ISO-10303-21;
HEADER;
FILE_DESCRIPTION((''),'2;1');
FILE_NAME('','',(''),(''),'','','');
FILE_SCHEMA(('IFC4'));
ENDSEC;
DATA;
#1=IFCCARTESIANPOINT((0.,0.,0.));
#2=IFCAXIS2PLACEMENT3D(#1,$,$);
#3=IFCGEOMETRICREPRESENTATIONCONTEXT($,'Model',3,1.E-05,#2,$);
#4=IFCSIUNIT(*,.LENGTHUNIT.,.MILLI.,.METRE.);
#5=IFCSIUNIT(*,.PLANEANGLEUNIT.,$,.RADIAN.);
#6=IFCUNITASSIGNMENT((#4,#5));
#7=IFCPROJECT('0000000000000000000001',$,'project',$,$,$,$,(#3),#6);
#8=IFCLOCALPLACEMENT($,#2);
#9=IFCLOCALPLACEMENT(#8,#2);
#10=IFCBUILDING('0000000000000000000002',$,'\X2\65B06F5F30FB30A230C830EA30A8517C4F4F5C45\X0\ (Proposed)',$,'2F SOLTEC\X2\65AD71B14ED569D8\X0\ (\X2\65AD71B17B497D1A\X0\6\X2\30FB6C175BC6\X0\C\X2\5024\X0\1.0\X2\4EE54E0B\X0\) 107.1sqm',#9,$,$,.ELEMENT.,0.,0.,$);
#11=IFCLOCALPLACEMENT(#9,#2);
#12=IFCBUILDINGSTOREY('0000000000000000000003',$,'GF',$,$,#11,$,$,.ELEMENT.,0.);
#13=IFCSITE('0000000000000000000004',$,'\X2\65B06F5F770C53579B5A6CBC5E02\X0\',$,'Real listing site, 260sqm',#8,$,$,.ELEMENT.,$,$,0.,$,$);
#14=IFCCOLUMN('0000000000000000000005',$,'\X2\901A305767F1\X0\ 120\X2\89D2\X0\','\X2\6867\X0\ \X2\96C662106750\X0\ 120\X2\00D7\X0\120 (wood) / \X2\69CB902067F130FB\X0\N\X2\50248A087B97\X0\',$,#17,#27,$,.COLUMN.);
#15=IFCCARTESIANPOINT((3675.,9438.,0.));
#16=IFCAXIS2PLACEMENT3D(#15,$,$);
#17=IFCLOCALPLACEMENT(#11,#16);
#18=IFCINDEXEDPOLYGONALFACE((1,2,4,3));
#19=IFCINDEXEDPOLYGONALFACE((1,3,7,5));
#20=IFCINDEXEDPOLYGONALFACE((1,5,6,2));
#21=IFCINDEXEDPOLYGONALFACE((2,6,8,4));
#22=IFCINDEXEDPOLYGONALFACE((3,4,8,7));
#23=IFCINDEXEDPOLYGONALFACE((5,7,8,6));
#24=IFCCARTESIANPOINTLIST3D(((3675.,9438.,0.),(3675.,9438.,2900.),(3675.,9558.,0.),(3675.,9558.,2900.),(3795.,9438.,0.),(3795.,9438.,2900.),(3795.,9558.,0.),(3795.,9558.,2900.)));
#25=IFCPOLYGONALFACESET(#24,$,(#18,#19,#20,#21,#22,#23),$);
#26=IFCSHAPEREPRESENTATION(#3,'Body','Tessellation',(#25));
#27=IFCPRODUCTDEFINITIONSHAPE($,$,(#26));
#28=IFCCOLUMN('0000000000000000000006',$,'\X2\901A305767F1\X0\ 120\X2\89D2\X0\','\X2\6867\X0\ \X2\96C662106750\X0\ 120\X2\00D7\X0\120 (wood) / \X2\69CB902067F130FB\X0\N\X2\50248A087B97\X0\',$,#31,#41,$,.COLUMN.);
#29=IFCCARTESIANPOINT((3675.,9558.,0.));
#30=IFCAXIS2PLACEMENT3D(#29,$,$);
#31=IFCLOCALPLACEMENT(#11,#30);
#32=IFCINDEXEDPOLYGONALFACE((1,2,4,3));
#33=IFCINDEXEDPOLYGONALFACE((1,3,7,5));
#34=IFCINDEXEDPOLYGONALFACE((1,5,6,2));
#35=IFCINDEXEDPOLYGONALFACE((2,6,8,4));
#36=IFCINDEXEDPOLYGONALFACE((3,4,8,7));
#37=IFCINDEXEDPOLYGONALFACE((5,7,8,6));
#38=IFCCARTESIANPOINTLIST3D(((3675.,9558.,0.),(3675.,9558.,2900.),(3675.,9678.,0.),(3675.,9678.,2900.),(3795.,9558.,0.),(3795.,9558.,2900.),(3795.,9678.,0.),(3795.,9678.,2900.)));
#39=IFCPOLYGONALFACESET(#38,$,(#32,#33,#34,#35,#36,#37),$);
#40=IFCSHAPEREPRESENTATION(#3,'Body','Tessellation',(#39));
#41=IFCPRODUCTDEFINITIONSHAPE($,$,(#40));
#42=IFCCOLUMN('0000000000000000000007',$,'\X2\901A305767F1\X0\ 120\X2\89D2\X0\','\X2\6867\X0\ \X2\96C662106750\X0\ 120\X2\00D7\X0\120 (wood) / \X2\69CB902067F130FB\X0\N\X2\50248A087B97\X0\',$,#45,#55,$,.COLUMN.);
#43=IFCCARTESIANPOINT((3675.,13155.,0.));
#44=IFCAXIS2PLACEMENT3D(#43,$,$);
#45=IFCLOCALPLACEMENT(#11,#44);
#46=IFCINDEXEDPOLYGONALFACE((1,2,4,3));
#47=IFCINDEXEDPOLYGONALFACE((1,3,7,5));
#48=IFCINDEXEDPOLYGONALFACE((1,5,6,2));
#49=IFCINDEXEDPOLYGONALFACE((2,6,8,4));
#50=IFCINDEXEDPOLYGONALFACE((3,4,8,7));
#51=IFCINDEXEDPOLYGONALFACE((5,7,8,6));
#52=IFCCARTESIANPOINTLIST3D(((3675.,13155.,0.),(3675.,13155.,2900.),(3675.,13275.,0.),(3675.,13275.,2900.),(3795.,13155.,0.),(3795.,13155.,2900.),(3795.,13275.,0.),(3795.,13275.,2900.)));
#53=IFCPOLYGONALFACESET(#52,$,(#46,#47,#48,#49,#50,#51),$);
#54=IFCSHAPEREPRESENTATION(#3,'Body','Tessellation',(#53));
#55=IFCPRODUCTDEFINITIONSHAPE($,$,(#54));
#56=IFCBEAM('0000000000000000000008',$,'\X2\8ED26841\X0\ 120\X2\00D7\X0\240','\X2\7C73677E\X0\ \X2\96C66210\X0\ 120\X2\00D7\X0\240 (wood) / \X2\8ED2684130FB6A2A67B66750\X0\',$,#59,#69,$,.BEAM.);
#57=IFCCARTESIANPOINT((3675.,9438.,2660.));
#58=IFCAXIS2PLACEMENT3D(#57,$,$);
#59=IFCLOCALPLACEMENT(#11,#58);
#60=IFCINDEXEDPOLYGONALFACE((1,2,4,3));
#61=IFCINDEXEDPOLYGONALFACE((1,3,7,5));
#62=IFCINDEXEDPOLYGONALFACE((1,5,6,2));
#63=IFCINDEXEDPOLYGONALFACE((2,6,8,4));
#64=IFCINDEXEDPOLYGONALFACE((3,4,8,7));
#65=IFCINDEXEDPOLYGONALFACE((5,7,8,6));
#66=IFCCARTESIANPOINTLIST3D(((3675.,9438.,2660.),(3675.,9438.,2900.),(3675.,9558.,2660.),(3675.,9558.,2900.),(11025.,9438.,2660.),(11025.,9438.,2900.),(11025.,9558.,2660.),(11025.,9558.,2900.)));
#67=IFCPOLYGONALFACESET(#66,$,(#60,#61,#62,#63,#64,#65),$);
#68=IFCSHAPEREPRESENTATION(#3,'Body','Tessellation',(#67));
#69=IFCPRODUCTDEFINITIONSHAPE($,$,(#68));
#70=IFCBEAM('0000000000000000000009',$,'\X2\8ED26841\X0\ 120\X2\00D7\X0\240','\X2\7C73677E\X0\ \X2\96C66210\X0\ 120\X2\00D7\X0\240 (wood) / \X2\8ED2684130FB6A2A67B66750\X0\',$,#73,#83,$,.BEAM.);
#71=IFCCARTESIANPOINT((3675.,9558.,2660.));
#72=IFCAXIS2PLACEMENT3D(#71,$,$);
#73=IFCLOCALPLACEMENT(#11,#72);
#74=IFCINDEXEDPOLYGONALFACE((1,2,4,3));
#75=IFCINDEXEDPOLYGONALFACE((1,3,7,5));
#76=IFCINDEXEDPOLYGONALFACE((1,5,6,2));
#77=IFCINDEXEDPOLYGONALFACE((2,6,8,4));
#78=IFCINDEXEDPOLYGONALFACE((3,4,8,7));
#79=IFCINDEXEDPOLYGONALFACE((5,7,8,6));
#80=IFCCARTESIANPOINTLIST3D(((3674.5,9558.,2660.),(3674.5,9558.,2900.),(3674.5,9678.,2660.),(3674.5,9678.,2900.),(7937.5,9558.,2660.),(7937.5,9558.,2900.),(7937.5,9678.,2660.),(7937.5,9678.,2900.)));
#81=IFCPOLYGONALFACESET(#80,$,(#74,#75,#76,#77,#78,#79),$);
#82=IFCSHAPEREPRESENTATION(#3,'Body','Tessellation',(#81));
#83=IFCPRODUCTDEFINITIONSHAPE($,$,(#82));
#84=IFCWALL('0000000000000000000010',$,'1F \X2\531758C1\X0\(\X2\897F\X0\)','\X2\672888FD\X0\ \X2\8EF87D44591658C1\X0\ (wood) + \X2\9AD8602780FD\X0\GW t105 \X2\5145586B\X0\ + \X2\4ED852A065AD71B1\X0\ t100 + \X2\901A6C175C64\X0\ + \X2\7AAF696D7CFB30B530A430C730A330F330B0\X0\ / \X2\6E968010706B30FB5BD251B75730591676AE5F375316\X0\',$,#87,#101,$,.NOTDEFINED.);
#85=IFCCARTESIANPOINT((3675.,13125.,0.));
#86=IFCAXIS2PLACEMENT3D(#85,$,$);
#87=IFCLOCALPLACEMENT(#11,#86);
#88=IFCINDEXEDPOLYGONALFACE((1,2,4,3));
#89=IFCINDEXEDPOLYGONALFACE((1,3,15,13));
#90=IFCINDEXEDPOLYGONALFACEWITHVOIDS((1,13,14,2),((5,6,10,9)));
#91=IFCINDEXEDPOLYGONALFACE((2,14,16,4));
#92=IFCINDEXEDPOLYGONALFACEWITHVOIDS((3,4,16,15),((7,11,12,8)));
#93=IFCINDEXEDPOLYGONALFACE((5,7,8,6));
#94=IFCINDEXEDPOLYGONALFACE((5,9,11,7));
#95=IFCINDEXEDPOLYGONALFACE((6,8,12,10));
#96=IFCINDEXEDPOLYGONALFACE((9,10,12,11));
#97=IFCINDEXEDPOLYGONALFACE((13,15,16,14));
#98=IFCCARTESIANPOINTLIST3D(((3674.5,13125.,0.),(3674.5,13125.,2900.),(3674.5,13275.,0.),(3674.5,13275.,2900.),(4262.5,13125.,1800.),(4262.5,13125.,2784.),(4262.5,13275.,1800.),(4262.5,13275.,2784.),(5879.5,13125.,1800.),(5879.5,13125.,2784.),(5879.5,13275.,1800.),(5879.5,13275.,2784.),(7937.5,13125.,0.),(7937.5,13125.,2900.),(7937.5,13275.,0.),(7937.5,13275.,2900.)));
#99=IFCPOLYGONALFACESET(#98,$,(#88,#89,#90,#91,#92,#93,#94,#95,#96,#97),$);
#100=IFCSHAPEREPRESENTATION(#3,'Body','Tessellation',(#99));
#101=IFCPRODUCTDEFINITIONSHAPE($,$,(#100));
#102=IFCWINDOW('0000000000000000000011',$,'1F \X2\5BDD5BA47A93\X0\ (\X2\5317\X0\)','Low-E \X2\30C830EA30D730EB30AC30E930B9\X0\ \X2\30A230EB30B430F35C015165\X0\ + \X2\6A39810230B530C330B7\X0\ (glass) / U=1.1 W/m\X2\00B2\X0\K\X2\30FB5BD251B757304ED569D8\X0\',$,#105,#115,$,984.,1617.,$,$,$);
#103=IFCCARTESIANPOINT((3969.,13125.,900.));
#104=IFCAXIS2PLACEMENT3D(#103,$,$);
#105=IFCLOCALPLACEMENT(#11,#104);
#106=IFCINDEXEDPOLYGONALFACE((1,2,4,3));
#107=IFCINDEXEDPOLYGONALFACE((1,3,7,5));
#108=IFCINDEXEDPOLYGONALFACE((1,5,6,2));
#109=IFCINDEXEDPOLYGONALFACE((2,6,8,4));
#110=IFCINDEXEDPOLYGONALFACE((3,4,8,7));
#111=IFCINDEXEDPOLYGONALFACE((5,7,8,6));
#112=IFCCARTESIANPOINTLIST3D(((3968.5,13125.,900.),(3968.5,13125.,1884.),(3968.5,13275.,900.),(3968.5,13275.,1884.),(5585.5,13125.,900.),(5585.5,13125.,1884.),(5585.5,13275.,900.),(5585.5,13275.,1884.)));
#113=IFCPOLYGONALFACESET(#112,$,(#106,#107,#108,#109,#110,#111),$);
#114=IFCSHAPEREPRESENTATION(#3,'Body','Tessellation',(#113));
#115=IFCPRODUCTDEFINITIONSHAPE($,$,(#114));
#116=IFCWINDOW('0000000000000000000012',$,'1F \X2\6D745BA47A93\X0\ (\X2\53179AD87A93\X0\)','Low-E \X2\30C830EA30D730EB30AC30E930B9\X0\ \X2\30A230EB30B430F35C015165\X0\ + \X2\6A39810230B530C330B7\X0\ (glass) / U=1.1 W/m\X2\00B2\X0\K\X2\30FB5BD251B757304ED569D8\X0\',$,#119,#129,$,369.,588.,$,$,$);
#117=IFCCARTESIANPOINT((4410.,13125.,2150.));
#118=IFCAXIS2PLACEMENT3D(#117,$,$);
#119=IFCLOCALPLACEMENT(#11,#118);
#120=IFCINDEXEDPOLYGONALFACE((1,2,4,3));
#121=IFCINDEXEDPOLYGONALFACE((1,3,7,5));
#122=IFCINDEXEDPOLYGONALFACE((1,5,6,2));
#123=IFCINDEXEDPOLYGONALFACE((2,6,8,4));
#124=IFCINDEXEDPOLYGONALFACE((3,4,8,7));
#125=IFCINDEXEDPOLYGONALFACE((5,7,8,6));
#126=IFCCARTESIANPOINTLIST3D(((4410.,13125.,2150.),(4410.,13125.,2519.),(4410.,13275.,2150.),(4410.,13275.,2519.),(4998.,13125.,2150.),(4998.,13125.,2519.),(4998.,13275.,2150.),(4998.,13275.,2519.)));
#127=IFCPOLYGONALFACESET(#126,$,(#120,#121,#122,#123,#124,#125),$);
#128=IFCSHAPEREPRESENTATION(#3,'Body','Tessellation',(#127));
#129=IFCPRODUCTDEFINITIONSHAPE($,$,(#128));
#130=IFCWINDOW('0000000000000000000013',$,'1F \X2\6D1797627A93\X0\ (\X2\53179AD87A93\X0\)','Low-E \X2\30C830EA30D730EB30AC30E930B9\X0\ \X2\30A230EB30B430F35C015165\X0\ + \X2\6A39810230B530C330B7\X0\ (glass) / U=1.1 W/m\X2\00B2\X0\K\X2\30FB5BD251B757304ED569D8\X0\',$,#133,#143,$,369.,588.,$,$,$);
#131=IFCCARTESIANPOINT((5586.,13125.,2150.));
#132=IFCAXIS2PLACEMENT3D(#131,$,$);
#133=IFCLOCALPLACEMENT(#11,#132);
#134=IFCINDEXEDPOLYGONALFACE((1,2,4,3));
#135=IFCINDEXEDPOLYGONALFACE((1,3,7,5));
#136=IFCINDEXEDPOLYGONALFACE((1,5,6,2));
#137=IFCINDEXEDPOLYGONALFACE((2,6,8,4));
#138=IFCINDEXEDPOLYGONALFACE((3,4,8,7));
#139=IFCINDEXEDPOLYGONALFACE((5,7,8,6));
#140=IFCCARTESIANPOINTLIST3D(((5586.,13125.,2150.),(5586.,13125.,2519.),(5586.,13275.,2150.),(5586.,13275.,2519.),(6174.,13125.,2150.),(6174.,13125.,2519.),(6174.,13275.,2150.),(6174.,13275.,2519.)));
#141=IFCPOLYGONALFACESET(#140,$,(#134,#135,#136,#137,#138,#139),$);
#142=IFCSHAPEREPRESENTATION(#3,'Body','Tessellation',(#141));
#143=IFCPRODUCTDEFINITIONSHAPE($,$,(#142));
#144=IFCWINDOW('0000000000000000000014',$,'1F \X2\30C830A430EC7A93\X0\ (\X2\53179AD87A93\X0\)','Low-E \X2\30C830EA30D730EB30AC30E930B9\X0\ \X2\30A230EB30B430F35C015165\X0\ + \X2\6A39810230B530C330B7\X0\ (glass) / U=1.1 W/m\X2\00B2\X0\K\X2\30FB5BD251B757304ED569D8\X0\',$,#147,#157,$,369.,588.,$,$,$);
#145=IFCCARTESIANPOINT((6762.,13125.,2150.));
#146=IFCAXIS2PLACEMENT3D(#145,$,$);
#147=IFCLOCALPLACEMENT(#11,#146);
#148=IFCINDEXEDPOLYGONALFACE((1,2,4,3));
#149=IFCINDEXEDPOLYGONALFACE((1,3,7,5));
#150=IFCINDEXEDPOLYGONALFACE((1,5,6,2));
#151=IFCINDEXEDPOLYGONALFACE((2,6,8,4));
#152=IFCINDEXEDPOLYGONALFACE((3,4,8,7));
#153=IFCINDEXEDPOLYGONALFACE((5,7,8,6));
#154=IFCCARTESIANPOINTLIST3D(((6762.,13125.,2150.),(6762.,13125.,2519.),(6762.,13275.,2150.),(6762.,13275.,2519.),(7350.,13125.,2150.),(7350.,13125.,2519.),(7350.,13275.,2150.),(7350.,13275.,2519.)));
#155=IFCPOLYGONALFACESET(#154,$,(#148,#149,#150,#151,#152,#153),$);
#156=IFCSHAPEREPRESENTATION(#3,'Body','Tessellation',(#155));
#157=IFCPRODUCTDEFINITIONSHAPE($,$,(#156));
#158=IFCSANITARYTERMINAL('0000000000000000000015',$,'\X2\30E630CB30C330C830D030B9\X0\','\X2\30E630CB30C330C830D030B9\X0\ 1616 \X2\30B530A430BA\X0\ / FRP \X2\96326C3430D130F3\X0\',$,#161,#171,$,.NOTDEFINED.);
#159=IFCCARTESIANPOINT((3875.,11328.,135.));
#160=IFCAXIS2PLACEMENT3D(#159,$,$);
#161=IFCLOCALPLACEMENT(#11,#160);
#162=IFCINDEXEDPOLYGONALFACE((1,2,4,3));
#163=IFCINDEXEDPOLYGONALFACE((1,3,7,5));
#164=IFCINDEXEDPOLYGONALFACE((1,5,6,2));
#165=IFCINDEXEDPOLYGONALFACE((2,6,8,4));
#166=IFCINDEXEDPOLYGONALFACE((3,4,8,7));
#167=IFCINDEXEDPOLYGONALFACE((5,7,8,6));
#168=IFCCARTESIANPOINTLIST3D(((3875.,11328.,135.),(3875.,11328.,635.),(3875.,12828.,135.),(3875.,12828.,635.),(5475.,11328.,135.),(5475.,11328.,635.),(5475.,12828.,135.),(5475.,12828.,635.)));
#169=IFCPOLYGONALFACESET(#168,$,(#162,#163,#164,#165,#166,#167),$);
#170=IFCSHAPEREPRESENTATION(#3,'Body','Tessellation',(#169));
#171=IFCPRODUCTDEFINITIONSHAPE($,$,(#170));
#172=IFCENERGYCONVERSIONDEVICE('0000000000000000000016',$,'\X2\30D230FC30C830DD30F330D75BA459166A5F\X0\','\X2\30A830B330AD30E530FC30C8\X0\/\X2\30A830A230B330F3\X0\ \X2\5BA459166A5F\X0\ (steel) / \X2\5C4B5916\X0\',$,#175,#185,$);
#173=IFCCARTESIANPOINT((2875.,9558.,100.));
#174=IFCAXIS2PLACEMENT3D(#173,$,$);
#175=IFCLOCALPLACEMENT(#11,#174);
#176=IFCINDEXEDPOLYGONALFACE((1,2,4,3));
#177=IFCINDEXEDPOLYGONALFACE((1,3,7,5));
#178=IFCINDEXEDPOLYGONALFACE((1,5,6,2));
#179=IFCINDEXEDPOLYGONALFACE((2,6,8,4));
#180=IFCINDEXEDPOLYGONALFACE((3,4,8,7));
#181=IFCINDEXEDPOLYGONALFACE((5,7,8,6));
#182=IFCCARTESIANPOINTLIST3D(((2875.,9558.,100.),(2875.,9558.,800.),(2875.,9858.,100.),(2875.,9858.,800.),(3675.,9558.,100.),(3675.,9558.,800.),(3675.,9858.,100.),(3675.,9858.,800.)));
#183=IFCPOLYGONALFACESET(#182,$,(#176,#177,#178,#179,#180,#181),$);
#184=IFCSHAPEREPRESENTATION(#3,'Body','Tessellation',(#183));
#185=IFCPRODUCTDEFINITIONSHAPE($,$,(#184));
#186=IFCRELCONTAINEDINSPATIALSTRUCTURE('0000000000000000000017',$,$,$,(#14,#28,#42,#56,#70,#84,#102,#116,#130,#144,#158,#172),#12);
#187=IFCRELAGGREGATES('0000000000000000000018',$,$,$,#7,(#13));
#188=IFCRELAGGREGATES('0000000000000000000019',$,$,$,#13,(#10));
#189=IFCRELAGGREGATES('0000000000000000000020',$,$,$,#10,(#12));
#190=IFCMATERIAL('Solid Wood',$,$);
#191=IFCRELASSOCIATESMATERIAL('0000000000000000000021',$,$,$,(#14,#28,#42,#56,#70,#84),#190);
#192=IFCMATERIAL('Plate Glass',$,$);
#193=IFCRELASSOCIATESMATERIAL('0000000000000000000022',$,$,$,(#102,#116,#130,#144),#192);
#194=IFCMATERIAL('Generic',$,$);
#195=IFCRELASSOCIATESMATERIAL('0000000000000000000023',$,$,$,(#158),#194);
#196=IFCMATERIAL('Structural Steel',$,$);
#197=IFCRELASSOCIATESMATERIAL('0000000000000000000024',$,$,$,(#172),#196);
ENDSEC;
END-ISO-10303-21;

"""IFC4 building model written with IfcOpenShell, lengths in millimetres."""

from ifc_helpers import new_model, si_unit, frame, frame_2d, origin, place, context, project, spatial, rectangle, extrude, material, element, fill, save


model = new_model("IFC4")

# Units and contexts
model_context = context("Model", 3, precision=1e-05, world=origin())
ifc_project = project(units=[si_unit("LENGTHUNIT", "METRE", prefix="MILLI"), si_unit("PLANEANGLEUNIT", "RADIAN")], contexts=[model_context])

# Site, building, storey
site_placement = place(None, origin())
site = spatial("IfcSite", under=ifc_project, at=site_placement, Name="新潟県南魚沼市", ObjectType="Real listing site, 260sqm", CompositionType="ELEMENT", RefElevation=0.0)
building_placement = place(site_placement, origin())
building = spatial("IfcBuilding", under=site, at=building_placement, Name="新潟・アトリエ兼住居 (Proposed)", ObjectType="2F SOLTEC断熱仕様 (断熱等級6・気密C値1.0以下) 107.1sqm", CompositionType="ELEMENT", ElevationOfRefHeight=0.0, ElevationOfTerrain=0.0)
storey_placement = place(building_placement, origin())
storey = spatial("IfcBuildingStorey", under=building, at=storey_placement, Name="GF", CompositionType="ELEMENT", Elevation=0.0)

# Columns
ifc_material_1 = material(Name="Solid Wood")
column_1_placement = place(storey_placement, frame((3675.0, 9438.0, 0.0)))
element("IfcColumn", 1, at=column_1_placement, inside=storey, material=ifc_material_1, Name="通し柱 120角", Description="桧 集成材 120×120 (wood) / 構造柱・N値計算", PredefinedType="COLUMN", context=model_context, shape_type="SweptSolid", body=[
    extrude(rectangle(XDim=120.0, YDim=120.0, at=frame_2d((60.0, 60.0))), frame((3675.0, 9438.0, 0.0)), (0.0, 0.0, 1.0), 2900.0),
])
column_2_placement = place(storey_placement, frame((3675.0, 9558.0, 0.0)))
element("IfcColumn", 2, at=column_2_placement, inside=storey, material=ifc_material_1, Name="通し柱 120角", Description="桧 集成材 120×120 (wood) / 構造柱・N値計算", PredefinedType="COLUMN", context=model_context, shape_type="SweptSolid", body=[
    extrude(rectangle(XDim=120.0, YDim=120.0, at=frame_2d((60.0, 60.0))), frame((3675.0, 9558.0, 0.0)), (0.0, 0.0, 1.0), 2900.0),
])
column_3_placement = place(storey_placement, frame((3675.0, 13155.0, 0.0)))
element("IfcColumn", 3, at=column_3_placement, inside=storey, material=ifc_material_1, Name="通し柱 120角", Description="桧 集成材 120×120 (wood) / 構造柱・N値計算", PredefinedType="COLUMN", context=model_context, shape_type="SweptSolid", body=[
    extrude(rectangle(XDim=120.0, YDim=120.0, at=frame_2d((60.0, 60.0))), frame((3675.0, 13155.0, 0.0)), (0.0, 0.0, 1.0), 2900.0),
])

# Beams
beam_1_placement = place(storey_placement, frame((3675.0, 9438.0, 2660.0)))
element("IfcBeam", 4, at=beam_1_placement, inside=storey, material=ifc_material_1, Name="軒桁 120×240", Description="米松 集成 120×240 (wood) / 軒桁・横架材", PredefinedType="BEAM", context=model_context, shape_type="SweptSolid", body=[
    extrude(rectangle(XDim=7350.0, YDim=120.0, at=frame_2d((3675.0, 60.0))), frame((3675.0, 9438.0, 2660.0)), (0.0, 0.0, 1.0), 240.0),
])
beam_2_placement = place(storey_placement, frame((3675.0, 9558.0, 2660.0)))
element("IfcBeam", 5, at=beam_2_placement, inside=storey, material=ifc_material_1, Name="軒桁 120×240", Description="米松 集成 120×240 (wood) / 軒桁・横架材", PredefinedType="BEAM", context=model_context, shape_type="SweptSolid", body=[
    extrude(rectangle(XDim=4263.0, YDim=120.0, at=frame_2d((2131.0, 60.0))), frame((3675.0, 9558.0, 2660.0)), (0.0, 0.0, 1.0), 240.0),
])

# Wall, openings, windows
wall_1_placement = place(storey_placement, frame((3675.0, 13125.0, 0.0)))
wall_1 = element("IfcWall", 6, at=wall_1_placement, inside=storey, material=ifc_material_1, Name="1F 北壁(西)", Description="木製 軸組外壁 (wood) + 高性能GW t105 充填 + 付加断熱 t100 + 通気層 + 窯業系サイディング / 準耐火・寒冷地外皮強化", PredefinedType="NOTDEFINED", context=model_context, shape_type="SweptSolid", body=[
    extrude(rectangle(XDim=4263.0, YDim=150.0, at=frame_2d((2131.0, 75.0))), frame((3675.0, 13125.0, 0.0)), (0.0, 0.0, 1.0), 2900.0),
])
opening_1_placement = place(storey_placement, frame((3969.0, 13125.0, 900.0)))
opening_1 = element("IfcOpeningElement", 7, at=opening_1_placement, cuts=wall_1, PredefinedType="NOTDEFINED", context=model_context, shape_type="SweptSolid", body=[
    extrude(rectangle(XDim=1617.0, YDim=150.0, at=frame_2d((808.0, 75.0))), frame((3969.0, 13125.0, 900.0)), (0.0, 0.0, 1.0), 984.0),
])
opening_2_placement = place(storey_placement, frame((4410.0, 13125.0, 2150.0)))
opening_2 = element("IfcOpeningElement", 8, at=opening_2_placement, cuts=wall_1, PredefinedType="NOTDEFINED", context=model_context, shape_type="SweptSolid", body=[
    extrude(rectangle(XDim=588.0, YDim=150.0, at=frame_2d((294.0, 75.0))), frame((4410.0, 13125.0, 2150.0)), (0.0, 0.0, 1.0), 369.0),
])
opening_3_placement = place(storey_placement, frame((5586.0, 13125.0, 2150.0)))
opening_3 = element("IfcOpeningElement", 9, at=opening_3_placement, cuts=wall_1, PredefinedType="NOTDEFINED", context=model_context, shape_type="SweptSolid", body=[
    extrude(rectangle(XDim=588.0, YDim=150.0, at=frame_2d((294.0, 75.0))), frame((5586.0, 13125.0, 2150.0)), (0.0, 0.0, 1.0), 369.0),
])
opening_4_placement = place(storey_placement, frame((6762.0, 13125.0, 2150.0)))
opening_4 = element("IfcOpeningElement", 10, at=opening_4_placement, cuts=wall_1, PredefinedType="NOTDEFINED", context=model_context, shape_type="SweptSolid", body=[
    extrude(rectangle(XDim=588.0, YDim=150.0, at=frame_2d((294.0, 75.0))), frame((6762.0, 13125.0, 2150.0)), (0.0, 0.0, 1.0), 369.0),
])
ifc_material_2 = material(Name="Plate Glass")
window_1_placement = place(storey_placement, frame((3969.0, 13125.0, 900.0)))
window_1 = element("IfcWindow", 11, at=window_1_placement, inside=storey, material=ifc_material_2, Name="1F 寝室窓 (北)", Description="Low-E トリプルガラス アルゴン封入 + 樹脂サッシ (glass) / U=1.1 W/m²K・寒冷地仕様", OverallHeight=984.0, OverallWidth=1617.0, context=model_context, shape_type="SweptSolid", body=[
    extrude(rectangle(XDim=1617.0, YDim=150.0, at=frame_2d((808.0, 75.0))), frame((3969.0, 13125.0, 900.0)), (0.0, 0.0, 1.0), 984.0),
])
fill(opening_1, window_1)
window_2_placement = place(storey_placement, frame((4410.0, 13125.0, 2150.0)))
window_2 = element("IfcWindow", 12, at=window_2_placement, inside=storey, material=ifc_material_2, Name="1F 浴室窓 (北高窓)", Description="Low-E トリプルガラス アルゴン封入 + 樹脂サッシ (glass) / U=1.1 W/m²K・寒冷地仕様", OverallHeight=369.0, OverallWidth=588.0, context=model_context, shape_type="SweptSolid", body=[
    extrude(rectangle(XDim=588.0, YDim=150.0, at=frame_2d((294.0, 75.0))), frame((4410.0, 13125.0, 2150.0)), (0.0, 0.0, 1.0), 369.0),
])
fill(opening_2, window_2)
window_3_placement = place(storey_placement, frame((5586.0, 13125.0, 2150.0)))
window_3 = element("IfcWindow", 13, at=window_3_placement, inside=storey, material=ifc_material_2, Name="1F 洗面窓 (北高窓)", Description="Low-E トリプルガラス アルゴン封入 + 樹脂サッシ (glass) / U=1.1 W/m²K・寒冷地仕様", OverallHeight=369.0, OverallWidth=588.0, context=model_context, shape_type="SweptSolid", body=[
    extrude(rectangle(XDim=588.0, YDim=150.0, at=frame_2d((294.0, 75.0))), frame((5586.0, 13125.0, 2150.0)), (0.0, 0.0, 1.0), 369.0),
])
fill(opening_3, window_3)
window_4_placement = place(storey_placement, frame((6762.0, 13125.0, 2150.0)))
window_4 = element("IfcWindow", 14, at=window_4_placement, inside=storey, material=ifc_material_2, Name="1F トイレ窓 (北高窓)", Description="Low-E トリプルガラス アルゴン封入 + 樹脂サッシ (glass) / U=1.1 W/m²K・寒冷地仕様", OverallHeight=369.0, OverallWidth=588.0, context=model_context, shape_type="SweptSolid", body=[
    extrude(rectangle(XDim=588.0, YDim=150.0, at=frame_2d((294.0, 75.0))), frame((6762.0, 13125.0, 2150.0)), (0.0, 0.0, 1.0), 369.0),
])
fill(opening_4, window_4)

# Shared definitions
ifc_material_3 = material(Name="Generic")

# Sanitary terminal
sanitary_terminal_placement = place(storey_placement, frame((3875.0, 11328.0, 135.0)))
element("IfcSanitaryTerminal", 15, at=sanitary_terminal_placement, inside=storey, material=ifc_material_3, Name="ユニットバス", Description="ユニットバス 1616 サイズ / FRP 防水パン", PredefinedType="NOTDEFINED", context=model_context, shape_type="SweptSolid", body=[
    extrude(rectangle(XDim=1600.0, YDim=1500.0, at=frame_2d((800.0, 750.0))), frame((3875.0, 11328.0, 135.0)), (0.0, 0.0, 1.0), 500.0),
])

# Energy conversion device
ifc_material_4 = material(Name="Structural Steel")
energy_conversion_device_placement = place(storey_placement, frame((2875.0, 9558.0, 100.0)))
element("IfcEnergyConversionDevice", 16, at=energy_conversion_device_placement, inside=storey, material=ifc_material_4, Name="ヒートポンプ室外機", Description="エコキュート/エアコン 室外機 (steel) / 屋外", context=model_context, shape_type="SweptSolid", body=[
    extrude(rectangle(XDim=800.0, YDim=300.0, at=frame_2d((400.0, 150.0))), frame((2875.0, 9558.0, 100.0)), (0.0, 0.0, 1.0), 700.0),
])

save(model, "model.ifc")
